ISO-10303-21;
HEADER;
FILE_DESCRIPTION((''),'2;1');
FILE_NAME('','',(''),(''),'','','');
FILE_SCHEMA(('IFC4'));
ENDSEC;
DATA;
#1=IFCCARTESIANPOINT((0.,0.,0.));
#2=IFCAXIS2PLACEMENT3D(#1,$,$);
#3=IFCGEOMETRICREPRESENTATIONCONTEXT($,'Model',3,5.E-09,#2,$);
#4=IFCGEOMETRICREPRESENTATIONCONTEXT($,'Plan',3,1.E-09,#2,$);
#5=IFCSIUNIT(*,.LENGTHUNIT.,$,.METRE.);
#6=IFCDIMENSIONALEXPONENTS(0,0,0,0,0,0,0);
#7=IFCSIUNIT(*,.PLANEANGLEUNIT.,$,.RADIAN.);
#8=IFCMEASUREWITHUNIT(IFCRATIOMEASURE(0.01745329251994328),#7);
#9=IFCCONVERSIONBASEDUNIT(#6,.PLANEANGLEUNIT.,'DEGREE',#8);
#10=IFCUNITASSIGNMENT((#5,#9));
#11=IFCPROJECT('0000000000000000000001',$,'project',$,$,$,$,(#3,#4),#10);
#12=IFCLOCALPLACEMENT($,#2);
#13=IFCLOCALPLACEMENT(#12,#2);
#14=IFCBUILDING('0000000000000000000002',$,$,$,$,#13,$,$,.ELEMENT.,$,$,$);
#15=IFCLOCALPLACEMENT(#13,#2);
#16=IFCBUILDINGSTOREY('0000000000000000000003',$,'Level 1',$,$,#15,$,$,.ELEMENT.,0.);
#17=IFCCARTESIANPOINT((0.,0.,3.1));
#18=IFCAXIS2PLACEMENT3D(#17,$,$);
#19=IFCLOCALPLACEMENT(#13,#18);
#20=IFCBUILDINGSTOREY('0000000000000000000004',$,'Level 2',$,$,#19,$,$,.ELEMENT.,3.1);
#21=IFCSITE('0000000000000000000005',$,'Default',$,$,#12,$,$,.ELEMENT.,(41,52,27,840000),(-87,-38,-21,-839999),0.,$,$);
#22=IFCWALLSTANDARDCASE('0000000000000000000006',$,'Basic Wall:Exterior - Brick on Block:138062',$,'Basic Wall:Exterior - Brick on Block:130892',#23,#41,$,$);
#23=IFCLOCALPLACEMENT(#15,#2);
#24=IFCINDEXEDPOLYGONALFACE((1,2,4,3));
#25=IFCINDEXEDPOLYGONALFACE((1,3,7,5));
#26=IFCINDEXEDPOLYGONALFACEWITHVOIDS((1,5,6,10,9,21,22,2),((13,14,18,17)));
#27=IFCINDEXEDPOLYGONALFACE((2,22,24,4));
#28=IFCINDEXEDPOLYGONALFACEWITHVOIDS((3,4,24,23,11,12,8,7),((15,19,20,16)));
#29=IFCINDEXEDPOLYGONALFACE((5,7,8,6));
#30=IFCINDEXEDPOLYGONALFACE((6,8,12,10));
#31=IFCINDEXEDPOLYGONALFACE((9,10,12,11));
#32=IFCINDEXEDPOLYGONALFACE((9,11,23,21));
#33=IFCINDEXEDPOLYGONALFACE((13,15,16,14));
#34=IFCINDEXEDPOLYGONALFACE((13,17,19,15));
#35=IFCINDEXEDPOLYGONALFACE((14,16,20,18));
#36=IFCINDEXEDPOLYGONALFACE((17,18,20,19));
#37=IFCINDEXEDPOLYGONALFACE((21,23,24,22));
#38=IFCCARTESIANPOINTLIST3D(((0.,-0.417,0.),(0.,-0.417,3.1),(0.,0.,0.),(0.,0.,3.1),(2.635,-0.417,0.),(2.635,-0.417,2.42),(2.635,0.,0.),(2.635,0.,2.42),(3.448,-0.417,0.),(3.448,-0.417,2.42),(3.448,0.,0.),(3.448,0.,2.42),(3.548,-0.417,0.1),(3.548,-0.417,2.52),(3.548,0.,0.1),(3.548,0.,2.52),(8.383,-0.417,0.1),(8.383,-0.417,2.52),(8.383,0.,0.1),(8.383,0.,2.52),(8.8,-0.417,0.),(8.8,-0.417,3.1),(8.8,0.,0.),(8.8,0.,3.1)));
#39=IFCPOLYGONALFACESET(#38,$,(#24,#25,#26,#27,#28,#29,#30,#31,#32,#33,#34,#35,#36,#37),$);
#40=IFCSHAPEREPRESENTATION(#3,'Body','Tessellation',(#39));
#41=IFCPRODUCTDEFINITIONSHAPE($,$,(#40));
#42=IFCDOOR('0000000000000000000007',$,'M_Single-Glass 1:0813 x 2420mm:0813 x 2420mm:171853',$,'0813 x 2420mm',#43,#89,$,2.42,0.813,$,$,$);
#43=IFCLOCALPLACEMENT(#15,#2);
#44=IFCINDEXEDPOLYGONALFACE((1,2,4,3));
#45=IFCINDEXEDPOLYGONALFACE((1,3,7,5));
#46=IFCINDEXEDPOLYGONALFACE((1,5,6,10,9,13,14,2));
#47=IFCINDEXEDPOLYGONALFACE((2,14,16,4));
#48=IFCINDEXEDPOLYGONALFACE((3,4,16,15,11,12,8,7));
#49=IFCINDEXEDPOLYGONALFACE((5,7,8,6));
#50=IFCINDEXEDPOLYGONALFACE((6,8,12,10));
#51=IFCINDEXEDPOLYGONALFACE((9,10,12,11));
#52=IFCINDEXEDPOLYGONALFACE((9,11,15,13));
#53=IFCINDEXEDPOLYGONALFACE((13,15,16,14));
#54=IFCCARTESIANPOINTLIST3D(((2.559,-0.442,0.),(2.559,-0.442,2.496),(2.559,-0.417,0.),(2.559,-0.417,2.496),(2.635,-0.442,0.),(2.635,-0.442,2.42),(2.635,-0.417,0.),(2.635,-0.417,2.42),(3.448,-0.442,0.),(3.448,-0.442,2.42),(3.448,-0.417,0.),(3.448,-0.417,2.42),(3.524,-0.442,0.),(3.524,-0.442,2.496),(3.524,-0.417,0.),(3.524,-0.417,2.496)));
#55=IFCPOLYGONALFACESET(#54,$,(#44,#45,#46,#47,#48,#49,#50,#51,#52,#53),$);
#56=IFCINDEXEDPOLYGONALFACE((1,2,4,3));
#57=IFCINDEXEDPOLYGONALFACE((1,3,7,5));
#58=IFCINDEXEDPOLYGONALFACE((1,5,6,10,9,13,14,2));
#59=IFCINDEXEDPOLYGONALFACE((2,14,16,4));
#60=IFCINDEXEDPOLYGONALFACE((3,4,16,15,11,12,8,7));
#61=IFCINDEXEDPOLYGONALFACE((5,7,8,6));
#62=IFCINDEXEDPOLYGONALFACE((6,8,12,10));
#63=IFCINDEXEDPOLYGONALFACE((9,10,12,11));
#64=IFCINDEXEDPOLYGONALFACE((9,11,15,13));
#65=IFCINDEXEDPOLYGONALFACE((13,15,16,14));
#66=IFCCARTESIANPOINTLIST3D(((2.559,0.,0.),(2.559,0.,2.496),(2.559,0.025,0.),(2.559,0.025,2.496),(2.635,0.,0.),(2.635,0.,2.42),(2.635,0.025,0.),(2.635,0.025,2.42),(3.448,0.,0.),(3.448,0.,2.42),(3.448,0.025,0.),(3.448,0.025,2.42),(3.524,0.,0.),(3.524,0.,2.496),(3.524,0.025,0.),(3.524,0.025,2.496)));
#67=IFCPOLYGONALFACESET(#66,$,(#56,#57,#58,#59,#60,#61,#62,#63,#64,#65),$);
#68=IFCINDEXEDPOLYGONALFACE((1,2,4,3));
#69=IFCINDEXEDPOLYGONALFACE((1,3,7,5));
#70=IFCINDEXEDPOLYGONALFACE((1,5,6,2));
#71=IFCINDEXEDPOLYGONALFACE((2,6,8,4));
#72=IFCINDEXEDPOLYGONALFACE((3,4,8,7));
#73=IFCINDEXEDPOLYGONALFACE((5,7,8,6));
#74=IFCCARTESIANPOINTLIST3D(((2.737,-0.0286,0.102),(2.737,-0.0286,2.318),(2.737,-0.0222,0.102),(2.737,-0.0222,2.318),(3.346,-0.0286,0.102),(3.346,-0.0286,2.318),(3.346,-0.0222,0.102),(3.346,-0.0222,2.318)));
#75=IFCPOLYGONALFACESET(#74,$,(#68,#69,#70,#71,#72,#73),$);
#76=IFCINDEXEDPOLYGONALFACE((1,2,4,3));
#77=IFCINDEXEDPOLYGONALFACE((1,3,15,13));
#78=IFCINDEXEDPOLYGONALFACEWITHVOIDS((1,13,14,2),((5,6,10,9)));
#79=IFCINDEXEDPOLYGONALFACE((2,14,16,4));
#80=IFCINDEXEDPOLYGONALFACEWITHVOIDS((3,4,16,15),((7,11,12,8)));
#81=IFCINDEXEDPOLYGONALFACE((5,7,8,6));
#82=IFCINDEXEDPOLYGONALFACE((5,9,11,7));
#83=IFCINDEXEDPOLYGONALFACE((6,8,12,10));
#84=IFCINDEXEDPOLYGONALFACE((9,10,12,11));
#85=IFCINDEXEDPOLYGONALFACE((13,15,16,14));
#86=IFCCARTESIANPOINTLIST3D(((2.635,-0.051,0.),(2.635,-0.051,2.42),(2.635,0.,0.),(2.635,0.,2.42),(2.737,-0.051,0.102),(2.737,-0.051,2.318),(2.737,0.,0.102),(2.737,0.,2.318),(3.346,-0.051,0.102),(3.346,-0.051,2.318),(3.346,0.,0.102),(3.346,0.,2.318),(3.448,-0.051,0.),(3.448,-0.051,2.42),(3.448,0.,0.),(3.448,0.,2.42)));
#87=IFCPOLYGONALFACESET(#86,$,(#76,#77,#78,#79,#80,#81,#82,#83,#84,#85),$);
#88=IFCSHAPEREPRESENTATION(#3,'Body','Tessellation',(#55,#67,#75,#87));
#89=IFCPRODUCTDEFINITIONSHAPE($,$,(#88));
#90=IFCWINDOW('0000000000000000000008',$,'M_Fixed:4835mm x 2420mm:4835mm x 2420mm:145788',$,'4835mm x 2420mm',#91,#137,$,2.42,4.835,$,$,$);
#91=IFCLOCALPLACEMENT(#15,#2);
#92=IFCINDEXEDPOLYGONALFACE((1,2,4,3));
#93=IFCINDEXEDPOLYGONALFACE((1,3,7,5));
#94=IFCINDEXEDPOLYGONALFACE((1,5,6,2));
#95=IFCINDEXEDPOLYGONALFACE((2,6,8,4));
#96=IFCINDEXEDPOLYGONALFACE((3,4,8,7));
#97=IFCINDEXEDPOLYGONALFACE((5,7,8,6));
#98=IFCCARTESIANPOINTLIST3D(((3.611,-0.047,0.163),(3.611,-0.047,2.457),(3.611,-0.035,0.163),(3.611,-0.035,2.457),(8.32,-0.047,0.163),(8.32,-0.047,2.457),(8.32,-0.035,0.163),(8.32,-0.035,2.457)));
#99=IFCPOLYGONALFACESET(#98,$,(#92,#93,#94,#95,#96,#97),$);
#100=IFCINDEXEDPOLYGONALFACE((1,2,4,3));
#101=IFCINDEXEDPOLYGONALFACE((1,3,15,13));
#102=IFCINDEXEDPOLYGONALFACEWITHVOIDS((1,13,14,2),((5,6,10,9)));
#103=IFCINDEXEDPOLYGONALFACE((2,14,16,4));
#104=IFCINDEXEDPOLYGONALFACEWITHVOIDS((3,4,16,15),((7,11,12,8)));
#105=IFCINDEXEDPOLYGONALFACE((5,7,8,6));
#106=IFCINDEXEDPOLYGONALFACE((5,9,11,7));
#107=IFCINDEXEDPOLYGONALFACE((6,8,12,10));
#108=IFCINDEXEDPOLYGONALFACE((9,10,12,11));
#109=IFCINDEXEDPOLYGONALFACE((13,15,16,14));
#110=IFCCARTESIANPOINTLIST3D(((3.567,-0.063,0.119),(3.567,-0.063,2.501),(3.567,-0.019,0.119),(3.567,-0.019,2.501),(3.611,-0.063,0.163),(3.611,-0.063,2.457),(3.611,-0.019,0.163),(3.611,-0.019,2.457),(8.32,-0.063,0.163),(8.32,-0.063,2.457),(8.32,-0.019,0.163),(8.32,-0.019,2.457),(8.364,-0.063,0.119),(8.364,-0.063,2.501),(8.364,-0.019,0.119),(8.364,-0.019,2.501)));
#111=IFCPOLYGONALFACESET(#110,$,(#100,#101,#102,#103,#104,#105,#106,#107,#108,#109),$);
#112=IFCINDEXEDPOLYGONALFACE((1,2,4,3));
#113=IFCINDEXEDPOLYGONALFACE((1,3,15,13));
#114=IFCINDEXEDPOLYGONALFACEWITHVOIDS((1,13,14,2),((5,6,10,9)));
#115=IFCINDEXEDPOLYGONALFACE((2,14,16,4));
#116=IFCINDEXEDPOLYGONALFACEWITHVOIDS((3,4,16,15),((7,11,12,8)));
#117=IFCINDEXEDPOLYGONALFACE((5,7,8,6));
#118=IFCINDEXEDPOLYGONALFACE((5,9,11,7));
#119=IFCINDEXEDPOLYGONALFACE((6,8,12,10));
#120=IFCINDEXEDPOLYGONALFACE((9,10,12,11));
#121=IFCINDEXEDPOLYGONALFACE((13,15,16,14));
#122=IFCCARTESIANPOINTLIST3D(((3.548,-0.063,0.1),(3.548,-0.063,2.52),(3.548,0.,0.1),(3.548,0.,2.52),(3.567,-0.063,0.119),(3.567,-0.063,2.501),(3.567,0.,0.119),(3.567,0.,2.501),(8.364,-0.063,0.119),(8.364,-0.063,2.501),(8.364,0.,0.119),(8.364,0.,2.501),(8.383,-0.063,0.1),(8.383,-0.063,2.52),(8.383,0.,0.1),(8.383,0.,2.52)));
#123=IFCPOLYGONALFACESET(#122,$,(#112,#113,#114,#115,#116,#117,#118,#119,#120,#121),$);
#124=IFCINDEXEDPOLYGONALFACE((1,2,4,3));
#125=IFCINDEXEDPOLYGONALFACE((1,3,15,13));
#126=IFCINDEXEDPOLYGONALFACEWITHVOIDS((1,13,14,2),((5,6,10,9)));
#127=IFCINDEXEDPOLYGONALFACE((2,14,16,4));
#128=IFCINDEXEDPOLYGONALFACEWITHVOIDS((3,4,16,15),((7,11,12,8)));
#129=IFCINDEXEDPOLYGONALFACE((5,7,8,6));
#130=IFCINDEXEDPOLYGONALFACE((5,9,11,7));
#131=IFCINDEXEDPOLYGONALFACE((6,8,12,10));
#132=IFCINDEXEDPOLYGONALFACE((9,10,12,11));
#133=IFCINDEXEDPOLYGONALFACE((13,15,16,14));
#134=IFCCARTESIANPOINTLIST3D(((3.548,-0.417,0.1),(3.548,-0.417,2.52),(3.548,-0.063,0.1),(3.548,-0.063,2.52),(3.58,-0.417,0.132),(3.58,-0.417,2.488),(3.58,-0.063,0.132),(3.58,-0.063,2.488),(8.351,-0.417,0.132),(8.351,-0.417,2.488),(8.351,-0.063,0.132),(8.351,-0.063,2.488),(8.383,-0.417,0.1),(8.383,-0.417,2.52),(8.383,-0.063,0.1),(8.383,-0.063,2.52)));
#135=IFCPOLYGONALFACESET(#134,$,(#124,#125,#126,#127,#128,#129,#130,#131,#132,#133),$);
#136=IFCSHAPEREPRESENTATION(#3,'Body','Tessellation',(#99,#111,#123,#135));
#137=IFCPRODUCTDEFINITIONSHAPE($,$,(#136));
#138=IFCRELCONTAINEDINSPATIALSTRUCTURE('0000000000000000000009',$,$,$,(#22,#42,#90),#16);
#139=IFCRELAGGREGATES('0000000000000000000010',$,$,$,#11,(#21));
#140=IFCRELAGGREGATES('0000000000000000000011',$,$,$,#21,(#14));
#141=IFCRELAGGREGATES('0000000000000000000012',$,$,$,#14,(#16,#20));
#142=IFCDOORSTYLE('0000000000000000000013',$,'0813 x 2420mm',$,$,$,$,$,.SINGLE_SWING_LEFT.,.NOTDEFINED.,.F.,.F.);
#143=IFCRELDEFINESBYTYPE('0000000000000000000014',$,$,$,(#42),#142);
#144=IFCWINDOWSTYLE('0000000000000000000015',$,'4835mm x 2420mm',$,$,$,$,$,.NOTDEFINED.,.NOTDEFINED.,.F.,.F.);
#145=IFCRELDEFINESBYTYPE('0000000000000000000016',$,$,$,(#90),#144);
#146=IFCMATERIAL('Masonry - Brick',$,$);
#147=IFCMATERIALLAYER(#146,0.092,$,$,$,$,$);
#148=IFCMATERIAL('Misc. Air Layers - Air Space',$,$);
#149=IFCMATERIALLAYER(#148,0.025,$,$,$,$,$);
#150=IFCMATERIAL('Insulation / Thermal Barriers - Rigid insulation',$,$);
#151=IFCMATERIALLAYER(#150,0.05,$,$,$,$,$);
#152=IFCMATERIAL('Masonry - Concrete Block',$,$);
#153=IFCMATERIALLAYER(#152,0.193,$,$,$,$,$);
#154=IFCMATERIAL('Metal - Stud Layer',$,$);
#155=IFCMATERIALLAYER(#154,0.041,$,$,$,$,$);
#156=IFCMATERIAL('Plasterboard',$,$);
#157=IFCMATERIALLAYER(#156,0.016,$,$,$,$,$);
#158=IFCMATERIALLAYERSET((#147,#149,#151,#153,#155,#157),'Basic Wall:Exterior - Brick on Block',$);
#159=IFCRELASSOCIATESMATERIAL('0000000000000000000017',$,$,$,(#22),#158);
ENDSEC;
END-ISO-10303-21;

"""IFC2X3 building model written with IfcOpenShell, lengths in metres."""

from ifc_helpers import new_model, entity, si_unit, converted_unit, frame, frame_2d, origin, origin_2d_with_axis, place, context, project, spatial, polyline, rectangle, outline, extrude, source, transform, mapped, material, layer, layer_set, layer_usage, type_object, type_shapes, element, fill, save


model = new_model("IFC2X3")

# Units and contexts
model_context = context("Model", 3, precision=5e-09, world=origin())
plan_context = context("Plan", 3, precision=1e-09, world=origin())
ifc_project = project(units=[si_unit("LENGTHUNIT", "METRE"), converted_unit("PLANEANGLEUNIT", "DEGREE", entity("IfcRatioMeasure", 0.01745329251994328), si_unit("PLANEANGLEUNIT", "RADIAN"), dimensions=[0, 0, 0, 0, 0, 0, 0])], contexts=[model_context, plan_context])

# Site, building, storey
site_placement = place(None, origin())
site = spatial("IfcSite", under=ifc_project, at=site_placement, Name="Default", CompositionType="ELEMENT", RefLatitude=(41, 52, 27, 840000), RefLongitude=(-87, -38, -21, -839999), RefElevation=0.0)
building_placement = place(site_placement, origin())
building = spatial("IfcBuilding", under=site, at=building_placement, CompositionType="ELEMENT")
storey_1_placement = place(building_placement, origin())
storey_1 = spatial("IfcBuildingStorey", under=building, at=storey_1_placement, Name="Level 1", CompositionType="ELEMENT", Elevation=0.0)

# Shared definitions
ifc_material_1 = material(Name="Masonry - Brick")
ifc_layer_1 = layer(ifc_material_1, 0.092)
ifc_material_2 = material(Name="Misc. Air Layers - Air Space")
ifc_layer_2 = layer(ifc_material_2, 0.025)
ifc_material_3 = material(Name="Insulation / Thermal Barriers - Rigid insulation")
ifc_layer_3 = layer(ifc_material_3, 0.05)
ifc_material_4 = material(Name="Masonry - Concrete Block")
ifc_layer_4 = layer(ifc_material_4, 0.193)
ifc_material_5 = material(Name="Metal - Stud Layer")
ifc_layer_5 = layer(ifc_material_5, 0.041)
ifc_material_6 = material(Name="Plasterboard")
ifc_layer_6 = layer(ifc_material_6, 0.016)
ifc_layer_set_1 = layer_set([ifc_layer_1, ifc_layer_2, ifc_layer_3, ifc_layer_4, ifc_layer_5, ifc_layer_6], Name="Basic Wall:Exterior - Brick on Block")
ifc_layer_usage_1 = layer_usage(ifc_layer_set_1, "AXIS2", "NEGATIVE", 0.2085)

# Wall, openings, door, window
wall_1_placement = place(storey_1_placement, frame((0.0, -0.2085, 0.0)))
wall_1 = element("IfcWallStandardCase", 1, at=wall_1_placement, inside=storey_1, material=ifc_layer_usage_1, Name="Basic Wall:Exterior - Brick on Block:138062", ObjectType="Basic Wall:Exterior - Brick on Block:130892", context=model_context, shape_type="SweptSolid", body=[
    extrude(rectangle(XDim=8.8, YDim=0.417, at=frame_2d((4.4, 0.0), x_axis=(-1.0, 0.0))), origin(), (0.0, 0.0, 1.0), 3.1),
])
opening_1_placement = place(wall_1_placement, frame((3.548, -0.2085, 0.1)))
opening_1 = element("IfcOpeningElement", 2, at=opening_1_placement, cuts=wall_1, ObjectType="Opening", context=model_context, shape_type="SweptSolid", body=[
    extrude(rectangle(XDim=2.42, YDim=4.835, at=frame_2d((1.21, 2.4175), x_axis=(1.0, 0.0))), frame((0.0, 0.0, 0.0), z_axis=(0.0, 1.0, 0.0), x_axis=(0.0, 0.0, 1.0)), (0.0, 0.0, 1.0), 0.417),
])
opening_2_placement = place(wall_1_placement, frame((2.635, -0.2085, 0.0)))
opening_2 = element("IfcOpeningElement", 3, at=opening_2_placement, cuts=wall_1, ObjectType="Opening", context=model_context, shape_type="SweptSolid", body=[
    extrude(rectangle(XDim=0.813, YDim=2.42, at=frame_2d((1.21, 0.4065), x_axis=(0.0, -1.0))), frame((0.0, 0.0, 0.0), z_axis=(0.0, 1.0, 0.0), x_axis=(0.0, 0.0, 1.0)), (0.0, 0.0, 1.0), 0.417),
])
door_style_1 = type_object("IfcDoorStyle", Name="0813 x 2420mm", ConstructionType="NOTDEFINED", OperationType="SINGLE_SWING_LEFT", ParameterTakesPrecedence=False, Sizeable=False)
shared_shape_1 = source(origin(), model_context, "Body", "SweptSolid", [
    extrude(outline(polyline([(-0.4065, -1.191), (-0.4065, 1.229), (-0.4825, 1.229), (-0.4825, -1.267), (0.4825, -1.267), (0.4825, 1.229), (0.4065, 1.229), (0.4065, -1.191), (-0.4065, -1.191)])), frame((0.4065, 0.0, 1.229), z_axis=(0.0, 1.0, 0.0), x_axis=(1.0, 0.0, 0.0)), (0.0, 0.0, -1.0), 0.025),
    extrude(outline(polyline([(-0.4065, -1.191), (-0.4065, 1.229), (-0.4825, 1.229), (-0.4825, -1.267), (0.4825, -1.267), (0.4825, 1.229), (0.4065, 1.229), (0.4065, -1.191), (-0.4065, -1.191)])), frame((0.4065, 0.442, 1.229), z_axis=(0.0, 1.0, 0.0), x_axis=(1.0, 0.0, 0.0)), (0.0, 0.0, -1.0), 0.025),
    extrude(rectangle(XDim=0.609, YDim=0.0064, at=origin_2d_with_axis()), frame((0.4065, 0.3916, 0.102)), (0.0, 0.0, 1.0), 2.216),
    extrude(outline(polyline([(-1.21, -0.4065), (1.21, -0.4065), (1.21, 0.4065), (-1.21, 0.4065), (-1.21, -0.4065)]), holes=[polyline([(-1.108, 0.3045), (1.108, 0.3045), (1.108, -0.3045), (-1.108, -0.3045), (-1.108, 0.3045)])]), frame((0.4065, 0.417, 1.21), z_axis=(0.0, -1.0, 0.0), x_axis=(0.0, 0.0, -1.0)), (0.0, 0.0, 1.0), 0.051),
])
type_shapes(door_style_1, [shared_shape_1])
door_1_placement = place(opening_2_placement, origin())
door_1 = element("IfcDoor", 4, at=door_1_placement, inside=storey_1, type_object=door_style_1, Name="M_Single-Glass 1:0813 x 2420mm:0813 x 2420mm:171853", ObjectType="0813 x 2420mm", OverallHeight=2.42, OverallWidth=0.813, context=model_context, shape_type="MappedRepresentation", body=[
    mapped(shared_shape_1, transform((0.0, 0.0, 0.0), scale=1.0)),
])
fill(opening_2, door_1)
window_style_1 = type_object("IfcWindowStyle", Name="4835mm x 2420mm", ConstructionType="NOTDEFINED", OperationType="NOTDEFINED", ParameterTakesPrecedence=False, Sizeable=False)
shared_shape_2 = source(origin(), model_context, "Body", "SweptSolid", [
    extrude(rectangle(XDim=0.012, YDim=4.709, at=origin_2d_with_axis()), frame((2.4175, 0.376, 0.063), z_axis=(0.0, 0.0, 1.0), x_axis=(0.0, -1.0, 0.0)), (0.0, 0.0, 1.0), 2.294),
    extrude(outline(polyline([(-2.3985, -1.191), (2.3985, -1.191), (2.3985, 1.191), (-2.3985, 1.191), (-2.3985, -1.191)]), holes=[polyline([(-2.3545, -1.147), (-2.3545, 1.147), (2.3545, 1.147), (2.3545, -1.147), (-2.3545, -1.147)])]), frame((2.4175, 0.354, 1.21), z_axis=(0.0, 1.0, 0.0), x_axis=(1.0, 0.0, 0.0)), (0.0, 0.0, 1.0), 0.044),
    extrude(outline(polyline([(-2.4175, -1.21), (2.4175, -1.21), (2.4175, 1.21), (-2.4175, 1.21), (-2.4175, -1.21)]), holes=[polyline([(-2.3985, -1.191), (-2.3985, 1.191), (2.3985, 1.191), (2.3985, -1.191), (-2.3985, -1.191)])]), frame((2.4175, 0.354, 1.21), z_axis=(0.0, 1.0, 0.0), x_axis=(1.0, 0.0, 0.0)), (0.0, 0.0, 1.0), 0.063),
    extrude(outline(polyline([(-2.4175, -1.21), (2.4175, -1.21), (2.4175, 1.21), (-2.4175, 1.21), (-2.4175, -1.21)]), holes=[polyline([(-2.3855, -1.178), (-2.3855, 1.178), (2.3855, 1.178), (2.3855, -1.178), (-2.3855, -1.178)])]), frame((2.4175, 0.0, 1.21), z_axis=(0.0, 1.0, 0.0), x_axis=(1.0, 0.0, 0.0)), (0.0, 0.0, 1.0), 0.354),
])
type_shapes(window_style_1, [shared_shape_2])
window_1_placement = place(opening_1_placement, origin())
window_1 = element("IfcWindow", 5, at=window_1_placement, inside=storey_1, type_object=window_style_1, Name="M_Fixed:4835mm x 2420mm:4835mm x 2420mm:145788", ObjectType="4835mm x 2420mm", OverallHeight=2.42, OverallWidth=4.835, context=model_context, shape_type="MappedRepresentation", body=[
    mapped(shared_shape_2, transform((0.0, 0.0, 0.0), scale=1.0)),
])
fill(opening_1, window_1)

# Shared definitions
storey_2_placement = place(building_placement, frame((0.0, 0.0, 3.1)))
storey_2 = spatial("IfcBuildingStorey", under=building, at=storey_2_placement, Name="Level 2", CompositionType="ELEMENT", Elevation=3.1)

save(model, "model.ifc")
